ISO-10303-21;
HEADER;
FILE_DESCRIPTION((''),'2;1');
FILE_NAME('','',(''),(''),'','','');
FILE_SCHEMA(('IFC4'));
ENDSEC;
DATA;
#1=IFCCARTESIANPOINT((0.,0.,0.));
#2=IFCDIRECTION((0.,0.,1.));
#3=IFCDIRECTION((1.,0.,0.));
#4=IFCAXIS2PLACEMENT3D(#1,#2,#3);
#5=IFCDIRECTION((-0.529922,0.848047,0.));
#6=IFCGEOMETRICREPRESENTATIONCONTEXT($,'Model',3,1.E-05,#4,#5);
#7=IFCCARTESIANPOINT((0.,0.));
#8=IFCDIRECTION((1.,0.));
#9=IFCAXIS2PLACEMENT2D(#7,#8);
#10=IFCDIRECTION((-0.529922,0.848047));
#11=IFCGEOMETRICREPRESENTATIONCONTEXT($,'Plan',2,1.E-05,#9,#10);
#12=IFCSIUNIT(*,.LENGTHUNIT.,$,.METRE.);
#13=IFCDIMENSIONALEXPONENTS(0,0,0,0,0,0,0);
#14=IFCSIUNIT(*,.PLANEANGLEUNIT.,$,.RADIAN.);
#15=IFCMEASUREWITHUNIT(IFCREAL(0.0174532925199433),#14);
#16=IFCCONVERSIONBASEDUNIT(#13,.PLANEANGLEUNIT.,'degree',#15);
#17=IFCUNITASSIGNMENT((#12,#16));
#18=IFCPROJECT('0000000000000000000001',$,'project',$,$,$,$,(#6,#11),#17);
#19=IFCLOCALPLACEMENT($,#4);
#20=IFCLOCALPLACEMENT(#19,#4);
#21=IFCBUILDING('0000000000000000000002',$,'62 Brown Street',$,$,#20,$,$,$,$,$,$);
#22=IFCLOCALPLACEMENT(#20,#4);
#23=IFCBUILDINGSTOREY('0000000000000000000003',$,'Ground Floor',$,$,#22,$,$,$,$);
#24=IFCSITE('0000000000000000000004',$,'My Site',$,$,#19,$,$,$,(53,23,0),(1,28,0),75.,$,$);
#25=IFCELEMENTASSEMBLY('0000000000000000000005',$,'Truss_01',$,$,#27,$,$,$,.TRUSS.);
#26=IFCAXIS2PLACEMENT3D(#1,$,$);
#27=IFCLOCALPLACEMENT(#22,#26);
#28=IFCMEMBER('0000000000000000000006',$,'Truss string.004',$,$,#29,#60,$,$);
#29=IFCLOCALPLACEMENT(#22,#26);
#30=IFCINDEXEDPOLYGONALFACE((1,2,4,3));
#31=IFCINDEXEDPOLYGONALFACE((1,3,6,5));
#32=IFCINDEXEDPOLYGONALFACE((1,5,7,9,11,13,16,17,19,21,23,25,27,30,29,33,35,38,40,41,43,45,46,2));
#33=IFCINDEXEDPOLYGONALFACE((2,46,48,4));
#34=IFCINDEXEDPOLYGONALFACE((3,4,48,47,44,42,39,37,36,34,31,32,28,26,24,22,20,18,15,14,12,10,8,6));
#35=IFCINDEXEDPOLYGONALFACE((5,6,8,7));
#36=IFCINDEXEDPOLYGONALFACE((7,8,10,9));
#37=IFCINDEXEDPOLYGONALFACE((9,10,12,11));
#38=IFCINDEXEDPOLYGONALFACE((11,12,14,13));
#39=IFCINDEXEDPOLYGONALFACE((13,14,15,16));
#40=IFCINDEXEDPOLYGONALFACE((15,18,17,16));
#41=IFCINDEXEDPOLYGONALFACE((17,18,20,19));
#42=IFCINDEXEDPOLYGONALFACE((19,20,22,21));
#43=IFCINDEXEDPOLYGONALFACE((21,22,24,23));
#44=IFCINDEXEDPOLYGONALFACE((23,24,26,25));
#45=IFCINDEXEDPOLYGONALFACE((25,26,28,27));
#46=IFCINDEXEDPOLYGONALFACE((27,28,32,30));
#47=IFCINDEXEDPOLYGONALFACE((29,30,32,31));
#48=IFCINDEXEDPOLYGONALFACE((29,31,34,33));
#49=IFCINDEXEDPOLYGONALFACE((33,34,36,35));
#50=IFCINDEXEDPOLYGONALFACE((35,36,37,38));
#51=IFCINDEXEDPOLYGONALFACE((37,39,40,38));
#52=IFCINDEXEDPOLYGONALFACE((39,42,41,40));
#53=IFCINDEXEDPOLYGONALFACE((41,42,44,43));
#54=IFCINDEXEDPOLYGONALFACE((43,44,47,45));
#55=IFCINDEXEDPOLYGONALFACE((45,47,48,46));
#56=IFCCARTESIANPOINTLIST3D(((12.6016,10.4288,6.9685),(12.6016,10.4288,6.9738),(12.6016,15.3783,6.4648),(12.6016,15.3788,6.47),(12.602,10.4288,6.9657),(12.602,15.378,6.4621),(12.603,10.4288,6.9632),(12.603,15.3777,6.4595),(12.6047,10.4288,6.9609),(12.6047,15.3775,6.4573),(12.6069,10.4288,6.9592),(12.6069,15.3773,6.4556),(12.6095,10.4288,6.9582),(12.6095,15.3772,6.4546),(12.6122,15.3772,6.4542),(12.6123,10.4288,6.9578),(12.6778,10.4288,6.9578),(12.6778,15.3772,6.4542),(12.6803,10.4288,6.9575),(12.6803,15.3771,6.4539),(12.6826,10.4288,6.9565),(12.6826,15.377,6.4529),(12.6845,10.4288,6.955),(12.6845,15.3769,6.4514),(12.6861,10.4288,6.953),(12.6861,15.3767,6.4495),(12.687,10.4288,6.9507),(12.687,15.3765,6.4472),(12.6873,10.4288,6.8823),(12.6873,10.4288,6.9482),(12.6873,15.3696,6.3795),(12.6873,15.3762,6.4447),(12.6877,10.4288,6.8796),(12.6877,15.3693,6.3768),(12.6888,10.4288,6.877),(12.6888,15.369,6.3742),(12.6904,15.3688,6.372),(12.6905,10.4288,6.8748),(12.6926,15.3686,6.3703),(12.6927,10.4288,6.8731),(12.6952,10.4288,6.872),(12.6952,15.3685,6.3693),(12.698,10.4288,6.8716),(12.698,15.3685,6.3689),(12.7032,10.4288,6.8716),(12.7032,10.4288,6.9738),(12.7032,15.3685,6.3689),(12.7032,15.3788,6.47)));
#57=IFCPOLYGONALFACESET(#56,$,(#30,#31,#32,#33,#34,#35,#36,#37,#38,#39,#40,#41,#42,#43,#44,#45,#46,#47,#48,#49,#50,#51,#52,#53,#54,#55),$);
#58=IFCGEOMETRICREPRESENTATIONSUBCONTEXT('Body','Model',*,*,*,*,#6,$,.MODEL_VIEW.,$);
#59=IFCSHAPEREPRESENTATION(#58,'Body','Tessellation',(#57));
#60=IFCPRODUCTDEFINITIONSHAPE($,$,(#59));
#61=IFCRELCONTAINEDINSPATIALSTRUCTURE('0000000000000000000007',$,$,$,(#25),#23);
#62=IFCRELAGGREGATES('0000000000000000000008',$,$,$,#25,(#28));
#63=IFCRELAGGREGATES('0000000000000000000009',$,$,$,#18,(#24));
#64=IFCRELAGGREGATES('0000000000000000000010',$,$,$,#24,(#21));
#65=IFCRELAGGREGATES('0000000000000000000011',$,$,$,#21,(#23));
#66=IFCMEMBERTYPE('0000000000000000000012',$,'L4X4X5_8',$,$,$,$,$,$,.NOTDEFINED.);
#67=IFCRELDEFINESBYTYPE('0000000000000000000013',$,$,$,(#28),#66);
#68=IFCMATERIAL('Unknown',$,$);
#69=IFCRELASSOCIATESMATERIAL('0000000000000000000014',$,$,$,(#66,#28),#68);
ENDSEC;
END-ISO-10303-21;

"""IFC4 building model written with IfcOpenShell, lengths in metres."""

from ifc_helpers import new_model, entity, si_unit, converted_unit, direction, frame, origin_with_axes, origin_2d_with_axis, place, context, subcontext, project, spatial, l_section, extrude, clip, halfspace, material, material_profile, profile_set, profile_usage, type_object, element, aggregate, save


model = new_model("IFC4")

# Units and contexts
model_context = context("Model", 3, precision=1e-05, world=origin_with_axes(), true_north=direction((-0.529922, 0.848047, 0.0)))
plan_context = context("Plan", 2, precision=1e-05, world=origin_2d_with_axis(), true_north=direction((-0.529922, 0.848047)))
body_context = subcontext(model_context, "Body", "Model", "MODEL_VIEW")
ifc_project = project(units=[si_unit("LENGTHUNIT", "METRE"), converted_unit("PLANEANGLEUNIT", "degree", entity("IfcReal", 0.0174532925199433), si_unit("PLANEANGLEUNIT", "RADIAN"), dimensions=[0, 0, 0, 0, 0, 0, 0])], contexts=[model_context, plan_context])

# Site, building, storey
site_placement = place(None, origin_with_axes())
site = spatial("IfcSite", under=ifc_project, at=site_placement, Name="My Site", RefLatitude=(53, 23, 0), RefLongitude=(1, 28, 0), RefElevation=75.0)
building_placement = place(site_placement, origin_with_axes())
building = spatial("IfcBuilding", under=site, at=building_placement, Name="62 Brown Street")
storey_placement = place(building_placement, origin_with_axes())
storey = spatial("IfcBuildingStorey", under=building, at=storey_placement, Name="Ground Floor")

# Element assembly
ifc_material_1 = material(Name="Unknown")
assembly_1_placement = place(storey_placement, frame((12.7032, 10.4288, 6.9738), z_axis=(0.0, 0.0, 1.0), x_axis=(1.0, 0.0, 0.0)))
assembly_1 = element("IfcElementAssembly", 1, at=assembly_1_placement, inside=storey, Name="Truss_01", PredefinedType="TRUSS")

# Member
ifc_material_profile_1 = material_profile(ifc_material_1, l_section(Depth=0.1016, Width=0.1016, Thickness=0.0159, FilletRadius=0.0095, EdgeRadius=0.0106))
ifc_profile_set_1 = profile_set([ifc_material_profile_1])
member_type_1 = type_object("IfcMemberType", Name="L4X4X5_8", PredefinedType="NOTDEFINED", material=ifc_profile_set_1)
ifc_profile_usage_1 = profile_usage(ifc_profile_set_1, cardinal=5)
member_1_placement = place(assembly_1_placement, frame((-0.0508, 4.9449, -0.5543), z_axis=(0.000001, -0.994861, 0.101247), x_axis=(-1.0, -0.000001, 0.0)))
member_1 = element("IfcMember", 2, at=member_1_placement, type_object=member_type_1, material=ifc_profile_usage_1, Name="Truss string.004", context=body_context, shape_type="Clipping", body=[
    clip(extrude(l_section(Depth=0.1016, Width=0.1016, Thickness=0.0159, FilletRadius=0.0095, EdgeRadius=0.0106), origin_with_axes(), (0.0, 0.0, 1.0), 5.3242), halfspace(frame((16.4524, -0.0508, 4.9756), z_axis=(0.0, 0.101247, 0.994861), x_axis=(1.0, -0.000001, 0.0)), False)),
])
aggregate(assembly_1, [member_1])

save(model, "model.ifc")
